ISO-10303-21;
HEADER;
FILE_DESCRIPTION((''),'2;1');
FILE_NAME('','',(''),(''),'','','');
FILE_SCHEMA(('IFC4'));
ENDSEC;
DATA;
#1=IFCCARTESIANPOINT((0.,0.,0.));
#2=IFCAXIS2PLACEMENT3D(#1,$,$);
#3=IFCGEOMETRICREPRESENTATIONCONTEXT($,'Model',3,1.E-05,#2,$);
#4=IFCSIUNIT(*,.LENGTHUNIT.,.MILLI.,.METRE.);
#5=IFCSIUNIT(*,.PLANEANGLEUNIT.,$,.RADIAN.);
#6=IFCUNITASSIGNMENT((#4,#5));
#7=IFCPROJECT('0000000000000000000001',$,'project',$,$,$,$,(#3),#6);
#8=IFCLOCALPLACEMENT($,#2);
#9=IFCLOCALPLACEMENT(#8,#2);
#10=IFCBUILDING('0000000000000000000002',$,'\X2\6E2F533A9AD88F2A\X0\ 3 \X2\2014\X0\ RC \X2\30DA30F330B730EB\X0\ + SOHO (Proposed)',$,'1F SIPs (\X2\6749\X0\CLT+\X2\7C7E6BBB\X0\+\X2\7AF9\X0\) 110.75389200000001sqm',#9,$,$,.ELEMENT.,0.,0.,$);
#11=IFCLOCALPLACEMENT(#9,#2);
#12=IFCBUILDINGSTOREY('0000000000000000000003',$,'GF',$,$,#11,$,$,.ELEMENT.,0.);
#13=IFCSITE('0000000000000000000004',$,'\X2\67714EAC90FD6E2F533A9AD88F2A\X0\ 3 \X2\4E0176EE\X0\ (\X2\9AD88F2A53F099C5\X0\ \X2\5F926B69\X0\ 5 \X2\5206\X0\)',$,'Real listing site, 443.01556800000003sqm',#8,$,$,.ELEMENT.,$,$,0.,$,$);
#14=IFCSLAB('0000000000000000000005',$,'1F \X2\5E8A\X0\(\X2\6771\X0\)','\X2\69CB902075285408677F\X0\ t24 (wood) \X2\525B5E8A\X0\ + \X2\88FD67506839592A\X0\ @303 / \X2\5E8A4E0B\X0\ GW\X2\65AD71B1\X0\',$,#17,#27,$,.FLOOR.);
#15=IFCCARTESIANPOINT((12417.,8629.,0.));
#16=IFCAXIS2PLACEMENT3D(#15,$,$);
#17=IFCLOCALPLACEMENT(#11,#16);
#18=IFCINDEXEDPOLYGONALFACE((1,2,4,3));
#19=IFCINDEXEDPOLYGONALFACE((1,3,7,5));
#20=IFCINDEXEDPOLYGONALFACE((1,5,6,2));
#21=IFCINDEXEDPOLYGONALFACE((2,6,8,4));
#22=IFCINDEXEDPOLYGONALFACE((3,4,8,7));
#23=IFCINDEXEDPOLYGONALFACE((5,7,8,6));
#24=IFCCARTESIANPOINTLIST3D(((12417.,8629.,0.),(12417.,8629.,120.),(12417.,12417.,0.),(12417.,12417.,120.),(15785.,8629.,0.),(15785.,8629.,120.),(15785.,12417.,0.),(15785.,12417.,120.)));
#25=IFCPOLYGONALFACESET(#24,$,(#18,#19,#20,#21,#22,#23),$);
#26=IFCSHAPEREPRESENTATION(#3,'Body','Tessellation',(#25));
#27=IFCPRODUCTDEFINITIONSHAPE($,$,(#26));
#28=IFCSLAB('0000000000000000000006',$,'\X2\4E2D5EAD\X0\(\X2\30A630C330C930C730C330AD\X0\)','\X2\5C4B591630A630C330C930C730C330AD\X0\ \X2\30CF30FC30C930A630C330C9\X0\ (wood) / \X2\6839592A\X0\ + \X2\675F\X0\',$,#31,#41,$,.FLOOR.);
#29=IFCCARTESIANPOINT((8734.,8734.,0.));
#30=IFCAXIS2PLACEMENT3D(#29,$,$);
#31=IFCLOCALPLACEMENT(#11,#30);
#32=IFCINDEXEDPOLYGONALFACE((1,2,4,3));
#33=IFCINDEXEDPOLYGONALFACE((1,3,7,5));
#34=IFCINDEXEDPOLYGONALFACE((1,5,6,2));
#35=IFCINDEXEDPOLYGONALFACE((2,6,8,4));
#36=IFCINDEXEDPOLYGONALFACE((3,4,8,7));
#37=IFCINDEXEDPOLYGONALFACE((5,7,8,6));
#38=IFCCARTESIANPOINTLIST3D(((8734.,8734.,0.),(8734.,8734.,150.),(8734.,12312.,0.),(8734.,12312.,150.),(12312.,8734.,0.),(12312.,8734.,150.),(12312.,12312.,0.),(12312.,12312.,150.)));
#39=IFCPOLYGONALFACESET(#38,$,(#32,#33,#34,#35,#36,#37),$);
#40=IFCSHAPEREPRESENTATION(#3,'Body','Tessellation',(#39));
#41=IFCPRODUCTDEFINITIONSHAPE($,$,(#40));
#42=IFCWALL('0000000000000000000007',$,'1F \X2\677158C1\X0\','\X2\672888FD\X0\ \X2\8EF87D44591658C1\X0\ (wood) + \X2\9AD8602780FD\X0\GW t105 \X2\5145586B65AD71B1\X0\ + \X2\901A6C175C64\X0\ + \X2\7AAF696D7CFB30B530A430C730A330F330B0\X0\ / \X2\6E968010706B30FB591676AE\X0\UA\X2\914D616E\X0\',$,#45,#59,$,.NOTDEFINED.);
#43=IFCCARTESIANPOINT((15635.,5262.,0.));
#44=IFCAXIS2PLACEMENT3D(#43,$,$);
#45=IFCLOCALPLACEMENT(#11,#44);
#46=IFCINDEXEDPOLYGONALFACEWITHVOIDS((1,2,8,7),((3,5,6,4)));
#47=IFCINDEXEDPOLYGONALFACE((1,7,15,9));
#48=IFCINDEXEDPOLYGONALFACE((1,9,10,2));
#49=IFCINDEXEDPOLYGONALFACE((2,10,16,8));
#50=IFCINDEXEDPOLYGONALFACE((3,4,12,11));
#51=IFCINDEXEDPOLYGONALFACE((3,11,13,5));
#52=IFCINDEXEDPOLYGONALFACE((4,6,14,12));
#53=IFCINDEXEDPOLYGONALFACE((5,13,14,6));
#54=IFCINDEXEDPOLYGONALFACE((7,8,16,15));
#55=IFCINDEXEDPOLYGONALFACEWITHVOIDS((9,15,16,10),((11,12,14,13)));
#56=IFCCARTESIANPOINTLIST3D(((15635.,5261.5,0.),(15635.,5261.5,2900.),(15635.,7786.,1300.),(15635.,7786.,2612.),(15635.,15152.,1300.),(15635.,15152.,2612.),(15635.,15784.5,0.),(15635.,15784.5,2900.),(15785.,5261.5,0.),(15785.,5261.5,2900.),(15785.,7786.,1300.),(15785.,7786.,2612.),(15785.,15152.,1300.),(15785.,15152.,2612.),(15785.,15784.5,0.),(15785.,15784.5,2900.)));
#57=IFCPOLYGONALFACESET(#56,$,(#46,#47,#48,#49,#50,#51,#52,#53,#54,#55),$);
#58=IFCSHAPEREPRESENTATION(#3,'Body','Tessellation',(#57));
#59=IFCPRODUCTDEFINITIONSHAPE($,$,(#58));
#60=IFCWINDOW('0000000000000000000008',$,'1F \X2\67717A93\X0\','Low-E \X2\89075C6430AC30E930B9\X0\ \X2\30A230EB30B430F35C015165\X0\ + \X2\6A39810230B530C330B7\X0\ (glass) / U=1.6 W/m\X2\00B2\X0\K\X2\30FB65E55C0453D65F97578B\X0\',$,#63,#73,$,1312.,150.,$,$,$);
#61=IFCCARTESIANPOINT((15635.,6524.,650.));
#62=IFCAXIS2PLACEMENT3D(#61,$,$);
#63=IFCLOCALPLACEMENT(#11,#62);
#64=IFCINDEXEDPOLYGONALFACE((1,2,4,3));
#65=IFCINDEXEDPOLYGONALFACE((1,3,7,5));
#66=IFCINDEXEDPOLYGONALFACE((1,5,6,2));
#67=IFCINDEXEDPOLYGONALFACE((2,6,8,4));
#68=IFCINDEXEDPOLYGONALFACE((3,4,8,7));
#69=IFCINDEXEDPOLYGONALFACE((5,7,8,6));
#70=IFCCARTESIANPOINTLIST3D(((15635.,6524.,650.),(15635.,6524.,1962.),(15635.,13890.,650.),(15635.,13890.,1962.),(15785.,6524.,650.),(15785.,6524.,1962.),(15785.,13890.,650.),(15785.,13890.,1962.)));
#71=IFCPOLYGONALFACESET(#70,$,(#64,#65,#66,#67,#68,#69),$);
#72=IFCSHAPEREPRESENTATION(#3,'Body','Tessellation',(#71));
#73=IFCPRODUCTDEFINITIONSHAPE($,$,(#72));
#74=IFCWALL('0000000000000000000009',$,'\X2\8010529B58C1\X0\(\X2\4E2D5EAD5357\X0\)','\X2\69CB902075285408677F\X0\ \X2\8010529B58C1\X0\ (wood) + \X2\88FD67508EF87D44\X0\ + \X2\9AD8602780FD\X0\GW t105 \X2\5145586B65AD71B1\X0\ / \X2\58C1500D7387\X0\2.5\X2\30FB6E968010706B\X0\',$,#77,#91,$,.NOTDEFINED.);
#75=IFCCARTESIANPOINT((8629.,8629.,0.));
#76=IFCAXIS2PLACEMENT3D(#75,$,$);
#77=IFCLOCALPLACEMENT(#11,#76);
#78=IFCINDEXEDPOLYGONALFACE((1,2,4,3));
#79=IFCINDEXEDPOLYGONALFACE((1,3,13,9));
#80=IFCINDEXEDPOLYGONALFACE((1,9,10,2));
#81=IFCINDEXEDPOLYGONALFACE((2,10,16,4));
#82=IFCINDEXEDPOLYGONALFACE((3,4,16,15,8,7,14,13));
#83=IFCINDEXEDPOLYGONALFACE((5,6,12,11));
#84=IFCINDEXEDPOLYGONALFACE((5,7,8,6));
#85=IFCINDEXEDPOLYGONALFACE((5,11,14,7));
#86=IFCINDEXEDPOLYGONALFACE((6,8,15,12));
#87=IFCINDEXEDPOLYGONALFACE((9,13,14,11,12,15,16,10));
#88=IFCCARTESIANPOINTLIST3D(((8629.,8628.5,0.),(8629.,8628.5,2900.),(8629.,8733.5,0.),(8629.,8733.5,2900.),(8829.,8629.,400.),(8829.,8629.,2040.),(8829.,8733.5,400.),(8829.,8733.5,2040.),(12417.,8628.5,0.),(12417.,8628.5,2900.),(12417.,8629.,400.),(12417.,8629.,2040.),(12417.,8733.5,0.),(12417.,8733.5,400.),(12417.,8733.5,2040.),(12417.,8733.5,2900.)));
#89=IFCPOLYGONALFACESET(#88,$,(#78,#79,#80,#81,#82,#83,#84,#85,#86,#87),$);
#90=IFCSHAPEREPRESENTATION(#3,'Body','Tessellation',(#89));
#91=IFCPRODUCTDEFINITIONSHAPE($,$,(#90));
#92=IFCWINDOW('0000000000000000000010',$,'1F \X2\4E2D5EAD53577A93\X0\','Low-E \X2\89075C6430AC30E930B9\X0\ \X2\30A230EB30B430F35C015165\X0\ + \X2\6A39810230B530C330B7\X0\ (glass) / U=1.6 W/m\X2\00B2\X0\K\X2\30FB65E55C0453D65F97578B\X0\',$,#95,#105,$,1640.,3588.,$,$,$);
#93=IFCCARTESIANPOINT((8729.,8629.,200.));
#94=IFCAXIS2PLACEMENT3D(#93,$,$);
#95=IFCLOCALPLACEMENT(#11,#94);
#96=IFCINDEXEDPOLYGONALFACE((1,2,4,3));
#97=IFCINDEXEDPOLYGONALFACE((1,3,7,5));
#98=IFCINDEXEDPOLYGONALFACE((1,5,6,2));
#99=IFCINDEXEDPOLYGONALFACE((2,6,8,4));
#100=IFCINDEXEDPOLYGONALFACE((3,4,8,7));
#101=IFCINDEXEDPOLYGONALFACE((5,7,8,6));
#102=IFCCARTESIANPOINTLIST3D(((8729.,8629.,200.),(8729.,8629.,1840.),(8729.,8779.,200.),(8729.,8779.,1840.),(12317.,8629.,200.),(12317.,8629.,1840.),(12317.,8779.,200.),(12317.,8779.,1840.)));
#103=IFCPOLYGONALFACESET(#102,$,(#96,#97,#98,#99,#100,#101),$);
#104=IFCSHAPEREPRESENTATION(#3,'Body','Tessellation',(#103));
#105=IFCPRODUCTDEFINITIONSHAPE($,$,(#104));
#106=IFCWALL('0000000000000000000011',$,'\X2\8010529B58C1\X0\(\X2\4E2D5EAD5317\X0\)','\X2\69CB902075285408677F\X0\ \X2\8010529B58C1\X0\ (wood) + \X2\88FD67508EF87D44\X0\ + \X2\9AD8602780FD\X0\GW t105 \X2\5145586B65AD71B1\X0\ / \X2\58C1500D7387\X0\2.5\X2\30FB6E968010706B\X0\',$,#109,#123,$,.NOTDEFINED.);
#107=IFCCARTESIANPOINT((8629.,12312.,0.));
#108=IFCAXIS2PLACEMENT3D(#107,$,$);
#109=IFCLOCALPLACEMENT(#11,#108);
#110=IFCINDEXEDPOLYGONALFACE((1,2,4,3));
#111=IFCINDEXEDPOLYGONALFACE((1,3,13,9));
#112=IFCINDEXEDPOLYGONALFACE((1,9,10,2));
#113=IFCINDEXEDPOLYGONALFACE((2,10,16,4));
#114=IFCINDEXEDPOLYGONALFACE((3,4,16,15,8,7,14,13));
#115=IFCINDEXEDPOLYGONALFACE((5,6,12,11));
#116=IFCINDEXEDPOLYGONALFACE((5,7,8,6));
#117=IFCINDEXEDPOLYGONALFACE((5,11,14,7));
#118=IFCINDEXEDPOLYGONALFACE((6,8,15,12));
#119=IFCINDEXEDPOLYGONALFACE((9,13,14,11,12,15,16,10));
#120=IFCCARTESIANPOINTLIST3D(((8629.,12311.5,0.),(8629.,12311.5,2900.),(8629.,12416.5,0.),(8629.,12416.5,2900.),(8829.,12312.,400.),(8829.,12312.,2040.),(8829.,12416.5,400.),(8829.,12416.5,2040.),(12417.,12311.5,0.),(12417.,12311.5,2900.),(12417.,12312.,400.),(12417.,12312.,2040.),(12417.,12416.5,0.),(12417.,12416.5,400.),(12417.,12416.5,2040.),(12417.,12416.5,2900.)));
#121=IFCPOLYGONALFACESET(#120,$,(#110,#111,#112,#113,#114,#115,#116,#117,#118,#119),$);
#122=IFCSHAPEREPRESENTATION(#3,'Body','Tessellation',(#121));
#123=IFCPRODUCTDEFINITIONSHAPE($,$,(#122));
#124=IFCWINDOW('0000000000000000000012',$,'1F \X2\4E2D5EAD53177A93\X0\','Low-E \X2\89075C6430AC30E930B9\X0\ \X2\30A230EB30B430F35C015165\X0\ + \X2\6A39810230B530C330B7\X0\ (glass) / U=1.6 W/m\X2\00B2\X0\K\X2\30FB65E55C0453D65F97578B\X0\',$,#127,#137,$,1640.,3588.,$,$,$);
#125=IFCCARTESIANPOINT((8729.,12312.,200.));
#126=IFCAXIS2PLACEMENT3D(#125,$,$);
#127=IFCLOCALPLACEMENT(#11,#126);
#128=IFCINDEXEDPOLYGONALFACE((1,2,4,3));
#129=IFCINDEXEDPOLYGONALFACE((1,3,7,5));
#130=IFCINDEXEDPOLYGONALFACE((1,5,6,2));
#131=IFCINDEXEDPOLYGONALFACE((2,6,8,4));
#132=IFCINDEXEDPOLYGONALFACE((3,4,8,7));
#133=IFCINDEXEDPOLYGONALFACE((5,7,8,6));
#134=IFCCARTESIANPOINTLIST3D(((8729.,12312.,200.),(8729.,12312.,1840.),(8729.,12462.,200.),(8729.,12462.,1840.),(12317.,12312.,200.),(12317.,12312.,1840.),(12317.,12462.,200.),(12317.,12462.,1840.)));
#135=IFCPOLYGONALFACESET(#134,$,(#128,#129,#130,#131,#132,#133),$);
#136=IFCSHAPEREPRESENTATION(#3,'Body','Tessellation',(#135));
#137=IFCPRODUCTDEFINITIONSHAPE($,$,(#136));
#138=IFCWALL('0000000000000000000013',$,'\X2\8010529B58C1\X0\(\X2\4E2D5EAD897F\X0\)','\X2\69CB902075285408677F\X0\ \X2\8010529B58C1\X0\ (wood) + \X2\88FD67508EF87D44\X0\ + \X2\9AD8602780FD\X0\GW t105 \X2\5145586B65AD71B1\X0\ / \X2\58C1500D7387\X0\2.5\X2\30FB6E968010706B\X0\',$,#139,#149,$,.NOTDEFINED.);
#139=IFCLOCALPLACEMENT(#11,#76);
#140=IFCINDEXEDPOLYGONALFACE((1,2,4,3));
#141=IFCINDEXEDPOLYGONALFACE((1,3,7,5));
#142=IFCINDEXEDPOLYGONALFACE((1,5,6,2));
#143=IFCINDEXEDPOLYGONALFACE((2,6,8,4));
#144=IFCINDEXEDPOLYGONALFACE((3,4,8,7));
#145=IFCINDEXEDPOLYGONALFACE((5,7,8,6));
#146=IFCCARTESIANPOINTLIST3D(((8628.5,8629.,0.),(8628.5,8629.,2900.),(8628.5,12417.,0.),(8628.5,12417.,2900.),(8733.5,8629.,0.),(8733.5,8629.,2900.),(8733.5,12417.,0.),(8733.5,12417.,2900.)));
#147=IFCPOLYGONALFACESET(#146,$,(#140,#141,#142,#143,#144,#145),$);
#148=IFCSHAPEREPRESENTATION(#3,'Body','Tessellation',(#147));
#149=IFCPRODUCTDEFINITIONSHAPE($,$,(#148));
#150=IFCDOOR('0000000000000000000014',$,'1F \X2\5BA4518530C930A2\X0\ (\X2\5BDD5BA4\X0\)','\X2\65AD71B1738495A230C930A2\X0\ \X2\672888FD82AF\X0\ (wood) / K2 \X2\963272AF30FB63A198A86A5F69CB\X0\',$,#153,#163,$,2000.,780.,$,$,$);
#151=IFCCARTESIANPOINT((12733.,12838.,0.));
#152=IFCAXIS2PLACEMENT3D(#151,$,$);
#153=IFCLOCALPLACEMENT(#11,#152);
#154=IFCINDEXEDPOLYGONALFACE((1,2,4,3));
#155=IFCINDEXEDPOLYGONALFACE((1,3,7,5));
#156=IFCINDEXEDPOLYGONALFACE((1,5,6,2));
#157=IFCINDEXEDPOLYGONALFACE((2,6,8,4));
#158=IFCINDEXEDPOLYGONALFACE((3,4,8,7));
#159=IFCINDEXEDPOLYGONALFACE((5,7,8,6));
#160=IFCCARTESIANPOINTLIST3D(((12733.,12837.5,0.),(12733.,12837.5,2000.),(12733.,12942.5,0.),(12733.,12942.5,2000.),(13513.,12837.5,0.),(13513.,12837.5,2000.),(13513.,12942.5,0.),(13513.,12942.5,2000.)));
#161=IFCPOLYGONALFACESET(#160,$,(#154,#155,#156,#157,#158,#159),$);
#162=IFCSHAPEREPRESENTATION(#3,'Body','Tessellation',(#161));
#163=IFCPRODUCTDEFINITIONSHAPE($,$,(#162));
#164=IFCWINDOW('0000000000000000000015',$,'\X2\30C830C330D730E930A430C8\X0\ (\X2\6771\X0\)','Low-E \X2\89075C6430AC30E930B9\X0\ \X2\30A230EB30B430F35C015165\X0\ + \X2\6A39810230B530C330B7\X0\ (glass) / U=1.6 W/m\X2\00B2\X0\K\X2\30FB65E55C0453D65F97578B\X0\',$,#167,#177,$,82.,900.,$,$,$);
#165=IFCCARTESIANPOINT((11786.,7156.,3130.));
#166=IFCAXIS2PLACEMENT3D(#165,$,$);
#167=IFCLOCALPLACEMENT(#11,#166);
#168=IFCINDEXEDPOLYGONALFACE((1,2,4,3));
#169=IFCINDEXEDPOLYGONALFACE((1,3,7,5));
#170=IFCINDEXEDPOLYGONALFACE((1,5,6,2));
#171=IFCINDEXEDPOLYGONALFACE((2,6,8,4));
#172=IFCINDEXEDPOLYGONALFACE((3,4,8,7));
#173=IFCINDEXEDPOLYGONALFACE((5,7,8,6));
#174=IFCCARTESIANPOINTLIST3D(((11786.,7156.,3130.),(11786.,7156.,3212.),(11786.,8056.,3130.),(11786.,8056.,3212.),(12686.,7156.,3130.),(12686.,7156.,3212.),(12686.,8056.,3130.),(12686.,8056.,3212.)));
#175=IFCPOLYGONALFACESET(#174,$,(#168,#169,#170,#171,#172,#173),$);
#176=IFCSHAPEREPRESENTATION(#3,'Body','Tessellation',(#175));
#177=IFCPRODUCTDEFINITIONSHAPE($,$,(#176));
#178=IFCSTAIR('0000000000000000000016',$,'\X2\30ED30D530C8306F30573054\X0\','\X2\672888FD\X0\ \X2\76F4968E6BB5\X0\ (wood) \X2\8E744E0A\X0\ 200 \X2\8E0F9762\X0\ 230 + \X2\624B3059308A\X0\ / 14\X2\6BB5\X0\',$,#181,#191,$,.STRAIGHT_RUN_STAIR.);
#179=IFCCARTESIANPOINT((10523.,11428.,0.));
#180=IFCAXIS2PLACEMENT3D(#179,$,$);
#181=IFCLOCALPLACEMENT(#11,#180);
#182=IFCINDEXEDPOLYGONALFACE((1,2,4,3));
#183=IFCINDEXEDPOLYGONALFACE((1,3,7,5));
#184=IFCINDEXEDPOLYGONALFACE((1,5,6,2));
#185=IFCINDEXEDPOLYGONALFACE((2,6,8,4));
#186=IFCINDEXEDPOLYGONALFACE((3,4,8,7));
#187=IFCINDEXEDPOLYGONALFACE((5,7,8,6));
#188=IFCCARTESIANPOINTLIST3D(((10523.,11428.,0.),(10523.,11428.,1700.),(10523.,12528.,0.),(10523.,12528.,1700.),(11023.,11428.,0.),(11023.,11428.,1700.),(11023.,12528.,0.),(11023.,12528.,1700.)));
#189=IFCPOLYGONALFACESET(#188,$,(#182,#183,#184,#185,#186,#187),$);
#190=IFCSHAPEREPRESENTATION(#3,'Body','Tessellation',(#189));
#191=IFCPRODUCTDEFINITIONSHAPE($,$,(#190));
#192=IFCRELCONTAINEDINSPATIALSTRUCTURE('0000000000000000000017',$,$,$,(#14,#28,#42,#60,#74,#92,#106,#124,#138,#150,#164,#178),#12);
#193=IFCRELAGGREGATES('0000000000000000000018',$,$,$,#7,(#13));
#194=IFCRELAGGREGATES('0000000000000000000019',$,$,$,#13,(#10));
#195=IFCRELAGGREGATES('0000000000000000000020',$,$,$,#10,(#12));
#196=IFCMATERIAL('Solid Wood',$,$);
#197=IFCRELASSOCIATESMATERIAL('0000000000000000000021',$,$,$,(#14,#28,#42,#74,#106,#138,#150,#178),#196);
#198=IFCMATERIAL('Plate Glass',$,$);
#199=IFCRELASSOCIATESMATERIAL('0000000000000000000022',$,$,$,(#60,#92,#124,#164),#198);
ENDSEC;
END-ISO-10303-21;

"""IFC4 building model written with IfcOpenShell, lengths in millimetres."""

from ifc_helpers import new_model, si_unit, frame, frame_2d, origin, place, context, project, spatial, rectangle, extrude, material, element, fill, save


model = new_model("IFC4")

# Units and contexts
model_context = context("Model", 3, precision=1e-05, world=origin())
ifc_project = project(units=[si_unit("LENGTHUNIT", "METRE", prefix="MILLI"), si_unit("PLANEANGLEUNIT", "RADIAN")], contexts=[model_context])

# Site, building, storey
site_placement = place(None, origin())
site = spatial("IfcSite", under=ifc_project, at=site_placement, Name="東京都港区高輪 3 丁目 (高輪台駅 徒歩 5 分)", ObjectType="Real listing site, 443.01556800000003sqm", CompositionType="ELEMENT", RefElevation=0.0)
building_placement = place(site_placement, origin())
building = spatial("IfcBuilding", under=site, at=building_placement, Name="港区高輪 3 — RC ペンシル + SOHO (Proposed)", ObjectType="1F SIPs (杉CLT+籾殻+竹) 110.75389200000001sqm", CompositionType="ELEMENT", ElevationOfRefHeight=0.0, ElevationOfTerrain=0.0)
storey_placement = place(building_placement, origin())
storey = spatial("IfcBuildingStorey", under=building, at=storey_placement, Name="GF", CompositionType="ELEMENT", Elevation=0.0)

# Slabs
ifc_material_1 = material(Name="Solid Wood")
slab_1_placement = place(storey_placement, frame((12417.0, 8629.0, 0.0)))
element("IfcSlab", 1, at=slab_1_placement, inside=storey, material=ifc_material_1, Name="1F 床(東)", Description="構造用合板 t24 (wood) 剛床 + 製材根太 @303 / 床下 GW断熱", PredefinedType="FLOOR", context=model_context, shape_type="SweptSolid", body=[
    extrude(rectangle(XDim=3368.0, YDim=3788.0, at=frame_2d((1684.0, 1894.0))), frame((12417.0, 8629.0, 0.0)), (0.0, 0.0, 1.0), 120.0),
])
slab_2_placement = place(storey_placement, frame((8734.0, 8734.0, 0.0)))
element("IfcSlab", 2, at=slab_2_placement, inside=storey, material=ifc_material_1, Name="中庭(ウッドデッキ)", Description="屋外ウッドデッキ ハードウッド (wood) / 根太 + 束", PredefinedType="FLOOR", context=model_context, shape_type="SweptSolid", body=[
    extrude(rectangle(XDim=3578.0, YDim=3578.0, at=frame_2d((1789.0, 1789.0))), frame((8734.0, 8734.0, 0.0)), (0.0, 0.0, 1.0), 150.0),
])

# Walls, openings, windows
wall_1_placement = place(storey_placement, frame((15635.0, 5262.0, 0.0)))
wall_1 = element("IfcWall", 3, at=wall_1_placement, inside=storey, material=ifc_material_1, Name="1F 東壁", Description="木製 軸組外壁 (wood) + 高性能GW t105 充填断熱 + 通気層 + 窯業系サイディング / 準耐火・外皮UA配慮", PredefinedType="NOTDEFINED", context=model_context, shape_type="SweptSolid", body=[
    extrude(rectangle(XDim=150.0, YDim=10523.0, at=frame_2d((75.0, 5261.0))), frame((15635.0, 5262.0, 0.0)), (0.0, 0.0, 1.0), 2900.0),
])
opening_1_placement = place(storey_placement, frame((15635.0, 6524.0, 650.0)))
opening_1 = element("IfcOpeningElement", 4, at=opening_1_placement, cuts=wall_1, PredefinedType="NOTDEFINED", context=model_context, shape_type="SweptSolid", body=[
    extrude(rectangle(XDim=150.0, YDim=7366.0, at=frame_2d((75.0, 3683.0))), frame((15635.0, 6524.0, 650.0)), (0.0, 0.0, 1.0), 1312.0),
])
ifc_material_2 = material(Name="Plate Glass")
window_1_placement = place(storey_placement, frame((15635.0, 6524.0, 650.0)))
window_1 = element("IfcWindow", 5, at=window_1_placement, inside=storey, material=ifc_material_2, Name="1F 東窓", Description="Low-E 複層ガラス アルゴン封入 + 樹脂サッシ (glass) / U=1.6 W/m²K・日射取得型", OverallHeight=1312.0, OverallWidth=150.0, context=model_context, shape_type="SweptSolid", body=[
    extrude(rectangle(XDim=150.0, YDim=7366.0, at=frame_2d((75.0, 3683.0))), frame((15635.0, 6524.0, 650.0)), (0.0, 0.0, 1.0), 1312.0),
])
fill(opening_1, window_1)
wall_2_placement = place(storey_placement, frame((8629.0, 8629.0, 0.0)))
wall_2 = element("IfcWall", 6, at=wall_2_placement, inside=storey, material=ifc_material_1, Name="耐力壁(中庭南)", Description="構造用合板 耐力壁 (wood) + 製材軸組 + 高性能GW t105 充填断熱 / 壁倍率2.5・準耐火", PredefinedType="NOTDEFINED", context=model_context, shape_type="SweptSolid", body=[
    extrude(rectangle(XDim=3788.0, YDim=105.0, at=frame_2d((1894.0, 52.0))), frame((8629.0, 8629.0, 0.0)), (0.0, 0.0, 1.0), 2900.0),
])
opening_2_placement = place(storey_placement, frame((8729.0, 8629.0, 200.0)))
opening_2 = element("IfcOpeningElement", 7, at=opening_2_placement, cuts=wall_2, PredefinedType="NOTDEFINED", context=model_context, shape_type="SweptSolid", body=[
    extrude(rectangle(XDim=3588.0, YDim=150.0, at=frame_2d((1794.0, 75.0))), frame((8729.0, 8629.0, 200.0)), (0.0, 0.0, 1.0), 1640.0),
])
window_2_placement = place(storey_placement, frame((8729.0, 8629.0, 200.0)))
window_2 = element("IfcWindow", 8, at=window_2_placement, inside=storey, material=ifc_material_2, Name="1F 中庭南窓", Description="Low-E 複層ガラス アルゴン封入 + 樹脂サッシ (glass) / U=1.6 W/m²K・日射取得型", OverallHeight=1640.0, OverallWidth=3588.0, context=model_context, shape_type="SweptSolid", body=[
    extrude(rectangle(XDim=3588.0, YDim=150.0, at=frame_2d((1794.0, 75.0))), frame((8729.0, 8629.0, 200.0)), (0.0, 0.0, 1.0), 1640.0),
])
fill(opening_2, window_2)
wall_3_placement = place(storey_placement, frame((8629.0, 12312.0, 0.0)))
wall_3 = element("IfcWall", 9, at=wall_3_placement, inside=storey, material=ifc_material_1, Name="耐力壁(中庭北)", Description="構造用合板 耐力壁 (wood) + 製材軸組 + 高性能GW t105 充填断熱 / 壁倍率2.5・準耐火", PredefinedType="NOTDEFINED", context=model_context, shape_type="SweptSolid", body=[
    extrude(rectangle(XDim=3788.0, YDim=105.0, at=frame_2d((1894.0, 52.0))), frame((8629.0, 12312.0, 0.0)), (0.0, 0.0, 1.0), 2900.0),
])
opening_3_placement = place(storey_placement, frame((8729.0, 12312.0, 200.0)))
opening_3 = element("IfcOpeningElement", 10, at=opening_3_placement, cuts=wall_3, PredefinedType="NOTDEFINED", context=model_context, shape_type="SweptSolid", body=[
    extrude(rectangle(XDim=3588.0, YDim=150.0, at=frame_2d((1794.0, 75.0))), frame((8729.0, 12312.0, 200.0)), (0.0, 0.0, 1.0), 1640.0),
])
window_3_placement = place(storey_placement, frame((8729.0, 12312.0, 200.0)))
window_3 = element("IfcWindow", 11, at=window_3_placement, inside=storey, material=ifc_material_2, Name="1F 中庭北窓", Description="Low-E 複層ガラス アルゴン封入 + 樹脂サッシ (glass) / U=1.6 W/m²K・日射取得型", OverallHeight=1640.0, OverallWidth=3588.0, context=model_context, shape_type="SweptSolid", body=[
    extrude(rectangle(XDim=3588.0, YDim=150.0, at=frame_2d((1794.0, 75.0))), frame((8729.0, 12312.0, 200.0)), (0.0, 0.0, 1.0), 1640.0),
])
fill(opening_3, window_3)

# Wall
wall_4_placement = place(storey_placement, frame((8629.0, 8629.0, 0.0)))
element("IfcWall", 12, at=wall_4_placement, inside=storey, material=ifc_material_1, Name="耐力壁(中庭西)", Description="構造用合板 耐力壁 (wood) + 製材軸組 + 高性能GW t105 充填断熱 / 壁倍率2.5・準耐火", PredefinedType="NOTDEFINED", context=model_context, shape_type="SweptSolid", body=[
    extrude(rectangle(XDim=105.0, YDim=3788.0, at=frame_2d((52.0, 1894.0))), frame((8629.0, 8629.0, 0.0)), (0.0, 0.0, 1.0), 2900.0),
])

# Door
door_placement = place(storey_placement, frame((12733.0, 12838.0, 0.0)))
element("IfcDoor", 13, at=door_placement, inside=storey, material=ifc_material_1, Name="1F 室内ドア (寝室)", Description="断熱玄関ドア 木製芯 (wood) / K2 防犯・採風機構", OverallHeight=2000.0, OverallWidth=780.0, context=model_context, shape_type="SweptSolid", body=[
    extrude(rectangle(XDim=780.0, YDim=105.0, at=frame_2d((390.0, 52.0))), frame((12733.0, 12838.0, 0.0)), (0.0, 0.0, 1.0), 2000.0),
])

# Window
window_4_placement = place(storey_placement, frame((11786.0, 7156.0, 3130.0)))
element("IfcWindow", 14, at=window_4_placement, inside=storey, material=ifc_material_2, Name="トップライト (東)", Description="Low-E 複層ガラス アルゴン封入 + 樹脂サッシ (glass) / U=1.6 W/m²K・日射取得型", OverallHeight=82.0, OverallWidth=900.0, context=model_context, shape_type="SweptSolid", body=[
    extrude(rectangle(XDim=900.0, YDim=900.0, at=frame_2d((450.0, 450.0))), frame((11786.0, 7156.0, 3130.0)), (0.0, 0.0, 1.0), 82.0),
])

# Stair
stair_placement = place(storey_placement, frame((10523.0, 11428.0, 0.0)))
element("IfcStair", 15, at=stair_placement, inside=storey, material=ifc_material_1, Name="ロフトはしご", Description="木製 直階段 (wood) 蹴上 200 踏面 230 + 手すり / 14段", PredefinedType="STRAIGHT_RUN_STAIR", context=model_context, shape_type="SweptSolid", body=[
    extrude(rectangle(XDim=500.0, YDim=1100.0, at=frame_2d((250.0, 550.0))), frame((10523.0, 11428.0, 0.0)), (0.0, 0.0, 1.0), 1700.0),
])

save(model, "model.ifc")
